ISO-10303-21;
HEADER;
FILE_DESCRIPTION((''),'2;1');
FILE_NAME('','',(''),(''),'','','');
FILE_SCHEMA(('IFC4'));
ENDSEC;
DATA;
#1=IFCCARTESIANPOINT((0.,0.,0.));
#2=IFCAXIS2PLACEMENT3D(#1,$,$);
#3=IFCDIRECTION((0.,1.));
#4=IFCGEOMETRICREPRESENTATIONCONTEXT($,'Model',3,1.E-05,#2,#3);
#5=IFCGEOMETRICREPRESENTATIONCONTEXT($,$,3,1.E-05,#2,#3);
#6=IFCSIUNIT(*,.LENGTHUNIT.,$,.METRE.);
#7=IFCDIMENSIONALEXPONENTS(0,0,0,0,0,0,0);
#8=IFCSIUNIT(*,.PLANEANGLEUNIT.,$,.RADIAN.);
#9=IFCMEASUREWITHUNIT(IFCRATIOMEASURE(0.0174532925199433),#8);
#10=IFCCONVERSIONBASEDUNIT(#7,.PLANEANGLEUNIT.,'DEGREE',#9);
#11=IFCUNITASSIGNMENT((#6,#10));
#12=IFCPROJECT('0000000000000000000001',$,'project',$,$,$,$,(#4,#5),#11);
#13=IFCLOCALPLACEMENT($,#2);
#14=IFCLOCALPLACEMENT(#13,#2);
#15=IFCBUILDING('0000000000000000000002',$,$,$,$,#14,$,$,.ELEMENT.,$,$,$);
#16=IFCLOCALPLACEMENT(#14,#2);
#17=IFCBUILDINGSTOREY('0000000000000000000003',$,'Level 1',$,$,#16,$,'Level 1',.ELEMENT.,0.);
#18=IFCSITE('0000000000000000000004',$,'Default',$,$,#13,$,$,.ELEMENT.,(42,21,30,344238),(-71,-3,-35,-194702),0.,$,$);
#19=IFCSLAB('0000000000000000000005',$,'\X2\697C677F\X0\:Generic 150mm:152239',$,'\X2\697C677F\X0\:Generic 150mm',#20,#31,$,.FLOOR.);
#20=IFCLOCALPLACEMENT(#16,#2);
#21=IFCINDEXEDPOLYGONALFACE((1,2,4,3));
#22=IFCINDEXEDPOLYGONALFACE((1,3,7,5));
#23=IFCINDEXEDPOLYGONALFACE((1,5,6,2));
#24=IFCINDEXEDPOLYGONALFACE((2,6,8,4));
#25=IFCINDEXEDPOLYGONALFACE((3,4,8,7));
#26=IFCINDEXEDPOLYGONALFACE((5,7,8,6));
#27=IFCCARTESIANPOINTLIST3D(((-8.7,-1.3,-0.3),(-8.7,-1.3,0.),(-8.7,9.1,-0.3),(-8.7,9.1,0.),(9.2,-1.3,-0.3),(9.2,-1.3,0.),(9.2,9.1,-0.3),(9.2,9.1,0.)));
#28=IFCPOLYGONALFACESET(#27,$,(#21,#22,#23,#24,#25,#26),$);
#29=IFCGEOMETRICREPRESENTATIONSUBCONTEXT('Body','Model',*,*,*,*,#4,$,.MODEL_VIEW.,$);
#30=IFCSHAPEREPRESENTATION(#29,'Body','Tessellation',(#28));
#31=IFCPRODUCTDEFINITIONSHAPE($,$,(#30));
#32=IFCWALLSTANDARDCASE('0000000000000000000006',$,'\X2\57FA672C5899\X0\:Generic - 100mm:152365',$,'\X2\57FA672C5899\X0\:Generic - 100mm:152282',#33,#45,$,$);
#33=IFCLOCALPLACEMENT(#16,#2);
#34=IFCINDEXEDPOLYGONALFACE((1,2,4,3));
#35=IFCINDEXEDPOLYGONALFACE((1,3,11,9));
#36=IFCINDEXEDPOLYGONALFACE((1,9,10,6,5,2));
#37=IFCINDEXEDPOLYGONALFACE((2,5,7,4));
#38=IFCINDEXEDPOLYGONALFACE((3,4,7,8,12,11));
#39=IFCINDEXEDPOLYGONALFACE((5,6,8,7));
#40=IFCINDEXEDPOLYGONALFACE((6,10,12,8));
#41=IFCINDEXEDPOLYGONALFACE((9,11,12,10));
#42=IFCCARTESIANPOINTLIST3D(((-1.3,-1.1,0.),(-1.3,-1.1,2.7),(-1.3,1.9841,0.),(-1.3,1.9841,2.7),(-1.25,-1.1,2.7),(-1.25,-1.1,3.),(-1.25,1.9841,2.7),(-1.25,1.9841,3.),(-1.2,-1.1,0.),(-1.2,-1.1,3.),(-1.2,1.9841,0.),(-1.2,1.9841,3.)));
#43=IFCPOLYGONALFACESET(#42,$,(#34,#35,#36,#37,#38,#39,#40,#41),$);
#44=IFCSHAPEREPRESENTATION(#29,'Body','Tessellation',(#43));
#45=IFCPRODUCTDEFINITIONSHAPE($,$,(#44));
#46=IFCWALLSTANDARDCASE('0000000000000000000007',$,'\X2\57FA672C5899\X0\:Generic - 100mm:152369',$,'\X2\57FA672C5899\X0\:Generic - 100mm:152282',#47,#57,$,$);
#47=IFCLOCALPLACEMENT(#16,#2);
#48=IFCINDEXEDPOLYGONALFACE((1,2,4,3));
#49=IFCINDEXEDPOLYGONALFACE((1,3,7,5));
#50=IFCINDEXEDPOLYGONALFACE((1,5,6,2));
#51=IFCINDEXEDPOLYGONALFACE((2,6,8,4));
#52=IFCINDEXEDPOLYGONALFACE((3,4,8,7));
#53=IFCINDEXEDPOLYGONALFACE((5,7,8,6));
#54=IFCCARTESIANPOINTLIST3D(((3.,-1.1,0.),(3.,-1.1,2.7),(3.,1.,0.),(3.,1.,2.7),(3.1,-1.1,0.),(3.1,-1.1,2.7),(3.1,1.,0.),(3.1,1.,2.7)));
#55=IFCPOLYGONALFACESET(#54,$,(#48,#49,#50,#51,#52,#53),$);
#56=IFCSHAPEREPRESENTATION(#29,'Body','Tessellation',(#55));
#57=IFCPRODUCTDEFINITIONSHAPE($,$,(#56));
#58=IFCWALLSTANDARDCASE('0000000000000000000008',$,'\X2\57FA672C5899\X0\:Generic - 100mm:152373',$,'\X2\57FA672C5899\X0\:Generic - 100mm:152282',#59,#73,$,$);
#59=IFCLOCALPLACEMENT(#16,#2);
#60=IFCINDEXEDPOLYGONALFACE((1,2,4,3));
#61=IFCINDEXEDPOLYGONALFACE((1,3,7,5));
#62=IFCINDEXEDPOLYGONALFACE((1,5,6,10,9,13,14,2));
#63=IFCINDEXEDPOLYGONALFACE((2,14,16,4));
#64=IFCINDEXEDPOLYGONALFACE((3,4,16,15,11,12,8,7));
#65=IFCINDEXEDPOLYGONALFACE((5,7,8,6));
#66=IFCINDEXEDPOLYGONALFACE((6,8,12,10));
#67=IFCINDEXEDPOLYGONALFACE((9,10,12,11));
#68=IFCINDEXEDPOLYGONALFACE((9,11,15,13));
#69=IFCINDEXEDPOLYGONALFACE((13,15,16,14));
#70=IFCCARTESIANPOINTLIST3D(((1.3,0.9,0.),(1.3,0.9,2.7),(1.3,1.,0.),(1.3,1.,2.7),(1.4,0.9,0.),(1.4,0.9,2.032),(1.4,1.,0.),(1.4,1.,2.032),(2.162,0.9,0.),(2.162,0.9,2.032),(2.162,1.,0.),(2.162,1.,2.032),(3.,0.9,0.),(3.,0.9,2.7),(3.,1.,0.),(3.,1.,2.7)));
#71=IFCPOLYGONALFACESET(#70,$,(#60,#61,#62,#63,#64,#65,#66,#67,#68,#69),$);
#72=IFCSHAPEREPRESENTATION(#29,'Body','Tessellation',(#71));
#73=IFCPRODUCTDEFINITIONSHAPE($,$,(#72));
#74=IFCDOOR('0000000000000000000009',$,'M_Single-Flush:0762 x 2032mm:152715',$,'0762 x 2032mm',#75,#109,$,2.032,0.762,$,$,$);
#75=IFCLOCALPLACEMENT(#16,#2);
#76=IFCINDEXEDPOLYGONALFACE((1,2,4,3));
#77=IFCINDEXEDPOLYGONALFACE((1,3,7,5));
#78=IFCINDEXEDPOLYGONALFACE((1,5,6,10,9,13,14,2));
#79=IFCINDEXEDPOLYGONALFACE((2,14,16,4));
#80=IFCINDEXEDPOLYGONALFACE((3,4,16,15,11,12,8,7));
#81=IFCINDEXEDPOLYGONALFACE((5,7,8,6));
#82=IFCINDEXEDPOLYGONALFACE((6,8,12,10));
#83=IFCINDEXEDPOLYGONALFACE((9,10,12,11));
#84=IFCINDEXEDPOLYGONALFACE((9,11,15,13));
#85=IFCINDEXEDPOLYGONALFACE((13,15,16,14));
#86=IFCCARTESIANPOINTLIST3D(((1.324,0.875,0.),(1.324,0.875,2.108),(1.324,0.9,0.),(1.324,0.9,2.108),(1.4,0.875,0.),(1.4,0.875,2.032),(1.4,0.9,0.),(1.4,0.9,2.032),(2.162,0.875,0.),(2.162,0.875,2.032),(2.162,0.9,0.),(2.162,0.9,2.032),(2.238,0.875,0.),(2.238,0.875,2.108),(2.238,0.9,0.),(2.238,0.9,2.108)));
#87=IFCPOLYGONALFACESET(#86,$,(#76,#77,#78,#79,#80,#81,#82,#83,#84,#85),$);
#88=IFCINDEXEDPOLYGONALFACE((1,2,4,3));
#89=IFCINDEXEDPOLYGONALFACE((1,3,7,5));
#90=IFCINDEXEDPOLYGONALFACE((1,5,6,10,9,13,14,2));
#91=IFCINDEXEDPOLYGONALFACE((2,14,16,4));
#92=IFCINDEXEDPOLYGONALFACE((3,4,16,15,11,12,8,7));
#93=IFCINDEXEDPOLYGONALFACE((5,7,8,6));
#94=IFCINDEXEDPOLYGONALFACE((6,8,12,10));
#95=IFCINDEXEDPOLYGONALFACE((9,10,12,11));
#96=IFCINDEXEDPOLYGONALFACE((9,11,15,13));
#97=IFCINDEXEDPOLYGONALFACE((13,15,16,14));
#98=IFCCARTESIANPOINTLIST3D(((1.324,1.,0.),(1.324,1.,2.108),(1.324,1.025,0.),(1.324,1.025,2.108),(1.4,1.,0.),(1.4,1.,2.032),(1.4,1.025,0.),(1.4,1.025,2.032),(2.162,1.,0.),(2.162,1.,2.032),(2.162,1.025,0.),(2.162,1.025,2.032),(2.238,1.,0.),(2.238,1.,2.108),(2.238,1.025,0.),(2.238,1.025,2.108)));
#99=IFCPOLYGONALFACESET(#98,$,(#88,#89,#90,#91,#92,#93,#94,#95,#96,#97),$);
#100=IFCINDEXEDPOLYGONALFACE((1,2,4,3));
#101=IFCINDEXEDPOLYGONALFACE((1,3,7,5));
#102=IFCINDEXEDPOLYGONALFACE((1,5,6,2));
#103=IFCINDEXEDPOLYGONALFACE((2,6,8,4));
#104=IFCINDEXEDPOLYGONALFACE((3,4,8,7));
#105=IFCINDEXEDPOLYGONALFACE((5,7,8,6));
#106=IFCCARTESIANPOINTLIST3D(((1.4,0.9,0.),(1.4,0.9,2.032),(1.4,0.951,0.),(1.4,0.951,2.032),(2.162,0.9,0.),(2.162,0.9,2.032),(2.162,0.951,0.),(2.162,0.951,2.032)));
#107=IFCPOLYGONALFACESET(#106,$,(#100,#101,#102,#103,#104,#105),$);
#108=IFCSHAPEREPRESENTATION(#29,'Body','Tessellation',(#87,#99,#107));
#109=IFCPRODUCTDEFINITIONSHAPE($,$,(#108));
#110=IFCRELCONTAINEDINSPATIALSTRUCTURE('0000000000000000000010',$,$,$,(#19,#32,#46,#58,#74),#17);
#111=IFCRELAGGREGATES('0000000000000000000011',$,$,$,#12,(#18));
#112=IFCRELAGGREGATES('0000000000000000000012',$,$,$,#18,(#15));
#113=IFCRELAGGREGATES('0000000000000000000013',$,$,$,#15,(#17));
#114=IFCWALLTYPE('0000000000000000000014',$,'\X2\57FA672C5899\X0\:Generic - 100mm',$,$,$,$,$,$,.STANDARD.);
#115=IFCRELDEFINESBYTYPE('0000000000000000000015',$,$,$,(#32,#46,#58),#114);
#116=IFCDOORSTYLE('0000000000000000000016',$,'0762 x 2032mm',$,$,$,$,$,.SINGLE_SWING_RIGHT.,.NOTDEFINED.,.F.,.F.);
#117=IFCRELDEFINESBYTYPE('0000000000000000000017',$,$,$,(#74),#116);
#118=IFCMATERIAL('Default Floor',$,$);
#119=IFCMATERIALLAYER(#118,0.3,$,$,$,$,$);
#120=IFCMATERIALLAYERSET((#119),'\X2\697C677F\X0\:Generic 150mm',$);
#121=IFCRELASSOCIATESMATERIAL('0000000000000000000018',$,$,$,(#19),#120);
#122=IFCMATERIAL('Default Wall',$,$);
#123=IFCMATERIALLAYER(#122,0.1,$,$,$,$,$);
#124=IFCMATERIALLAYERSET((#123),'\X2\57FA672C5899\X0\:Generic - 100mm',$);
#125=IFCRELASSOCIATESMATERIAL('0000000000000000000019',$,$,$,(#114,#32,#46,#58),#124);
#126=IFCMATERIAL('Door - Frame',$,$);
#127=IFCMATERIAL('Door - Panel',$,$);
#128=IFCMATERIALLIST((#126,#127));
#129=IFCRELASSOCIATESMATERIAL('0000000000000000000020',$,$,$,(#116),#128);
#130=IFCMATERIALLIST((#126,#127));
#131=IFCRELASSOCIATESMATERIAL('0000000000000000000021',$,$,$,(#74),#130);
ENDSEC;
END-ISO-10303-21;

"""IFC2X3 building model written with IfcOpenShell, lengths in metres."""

from ifc_helpers import new_model, entity, si_unit, converted_unit, direction, frame, frame_2d, origin, origin_2d_with_axis, place, context, subcontext, project, spatial, polyline, rectangle, outline, extrude, clip, bounded_halfspace, source, transform, mapped, material, material_list, layer, layer_set, layer_usage, type_object, type_shapes, element, fill, save


model = new_model("IFC2X3")

# Units and contexts
model_context = context("Model", 3, precision=1e-05, world=origin(), true_north=direction((0.0, 1.0)))
context_of_model = context(None, 3, precision=1e-05, world=origin(), true_north=direction((0.0, 1.0)))
body_context = subcontext(model_context, "Body", "Model", "MODEL_VIEW")
ifc_project = project(units=[si_unit("LENGTHUNIT", "METRE"), converted_unit("PLANEANGLEUNIT", "DEGREE", entity("IfcRatioMeasure", 0.0174532925199433), si_unit("PLANEANGLEUNIT", "RADIAN"), dimensions=[0, 0, 0, 0, 0, 0, 0])], contexts=[model_context, context_of_model])

# Site, building, storey
site_placement = place(None, origin())
site = spatial("IfcSite", under=ifc_project, at=site_placement, Name="Default", CompositionType="ELEMENT", RefLatitude=(42, 21, 30, 344238), RefLongitude=(-71, -3, -35, -194702), RefElevation=0.0)
building_placement = place(site_placement, origin())
building = spatial("IfcBuilding", under=site, at=building_placement, CompositionType="ELEMENT")
storey_placement = place(building_placement, origin())
storey = spatial("IfcBuildingStorey", under=building, at=storey_placement, Name="Level 1", LongName="Level 1", CompositionType="ELEMENT", Elevation=0.0)

# Slab
ifc_material_1 = material(Name="Default Floor")
ifc_layer_1 = layer(ifc_material_1, 0.3)
ifc_layer_set_1 = layer_set([ifc_layer_1], Name="楼板:Generic 150mm")
ifc_layer_usage_1 = layer_usage(ifc_layer_set_1, "AXIS3", "POSITIVE", 0.0)
slab_1_placement = place(storey_placement, origin())
element("IfcSlab", 1, at=slab_1_placement, inside=storey, material=ifc_layer_usage_1, Name="楼板:Generic 150mm:152239", ObjectType="楼板:Generic 150mm", PredefinedType="FLOOR", context=body_context, shape_type="SweptSolid", body=[
    extrude(rectangle(XDim=10.4, YDim=17.9, at=origin_2d_with_axis()), frame((0.25, 3.9, 0.0), z_axis=(0.0, 0.0, -1.0), x_axis=(0.0, 1.0, 0.0)), (0.0, 0.0, 1.0), 0.3),
])

# Walls
ifc_material_2 = material(Name="Default Wall")
ifc_layer_2 = layer(ifc_material_2, 0.1)
ifc_layer_set_2 = layer_set([ifc_layer_2], Name="基本墙:Generic - 100mm")
ifc_layer_usage_2 = layer_usage(ifc_layer_set_2, "AXIS2", "NEGATIVE", 0.05)
wall_type = type_object("IfcWallType", Name="基本墙:Generic - 100mm", PredefinedType="STANDARD", material=ifc_layer_set_2)
wall_1_placement = place(storey_placement, frame((-1.25, -1.1, 0.0), z_axis=(0.0, 0.0, 1.0), x_axis=(0.0, 1.0, 0.0)))
element("IfcWallStandardCase", 2, at=wall_1_placement, inside=storey, type_object=wall_type, material=ifc_layer_usage_2, Name="基本墙:Generic - 100mm:152365", ObjectType="基本墙:Generic - 100mm:152282", context=body_context, shape_type="Clipping", body=[
    clip(clip(extrude(rectangle(XDim=3.0841, YDim=0.1, at=frame_2d((1.5421, 0.0), x_axis=(-1.0, 0.0))), origin(), (0.0, 0.0, 1.0), 3.0), bounded_halfspace(frame((0.0, 0.0, 2.7), z_axis=(0.0, 0.0, -1.0), x_axis=(-1.0, 0.0, 0.0)), True, frame((0.0, 0.0, 2.7), z_axis=(0.0, 0.0, -1.0), x_axis=(-1.0, 0.0, 0.0)), polyline([(0.0, 0.0), (0.0, 0.05), (-3.0841, 0.05), (-3.0841, 0.0), (0.0, 0.0)]))), bounded_halfspace(frame((3.0841, 0.0, 2.7), z_axis=(0.0, 1.0, 0.0), x_axis=(0.0, 0.0, -1.0)), False, frame((3.0841, 0.0, 2.7), z_axis=(0.0, 1.0, 0.0), x_axis=(0.0, 0.0, -1.0)), polyline([(0.0, 0.0), (0.0, 3.0841), (-0.3, 3.0841), (-0.3, 0.0), (0.0, 0.0)]))),
])
ifc_layer_usage_3 = layer_usage(ifc_layer_set_2, "AXIS2", "NEGATIVE", 0.05)
wall_2_placement = place(storey_placement, frame((3.05, 1.0, 0.0), z_axis=(0.0, 0.0, 1.0), x_axis=(0.0, -1.0, 0.0)))
element("IfcWallStandardCase", 3, at=wall_2_placement, inside=storey, type_object=wall_type, material=ifc_layer_usage_3, Name="基本墙:Generic - 100mm:152369", ObjectType="基本墙:Generic - 100mm:152282", context=body_context, shape_type="Clipping", body=[
    clip(extrude(rectangle(XDim=2.1, YDim=0.1, at=frame_2d((1.05, 0.0), x_axis=(-1.0, 0.0))), origin(), (0.0, 0.0, 1.0), 3.0), bounded_halfspace(frame((0.0, -0.05, 2.7), z_axis=(0.0, 0.0, -1.0), x_axis=(1.0, 0.0, 0.0)), True, frame((0.0, -0.05, 2.7), z_axis=(0.0, 0.0, -1.0), x_axis=(1.0, 0.0, 0.0)), polyline([(0.0, 0.0), (0.0, -0.1), (2.1, -0.1), (2.1, 0.0), (0.1, 0.0), (0.0, 0.0)]))),
])

# Wall, opening, door
ifc_layer_usage_4 = layer_usage(ifc_layer_set_2, "AXIS2", "NEGATIVE", 0.05)
wall_3_placement = place(storey_placement, frame((1.3, 0.95, 0.0)))
wall_3 = element("IfcWallStandardCase", 4, at=wall_3_placement, inside=storey, type_object=wall_type, material=ifc_layer_usage_4, Name="基本墙:Generic - 100mm:152373", ObjectType="基本墙:Generic - 100mm:152282", context=body_context, shape_type="Clipping", body=[
    clip(extrude(rectangle(XDim=1.7, YDim=0.1, at=frame_2d((0.85, 0.0), x_axis=(-1.0, 0.0))), origin(), (0.0, 0.0, 1.0), 3.0), bounded_halfspace(frame((0.0, -0.05, 2.7), z_axis=(0.0, 0.0, -1.0), x_axis=(0.0, -1.0, 0.0)), True, frame((0.0, -0.05, 2.7), z_axis=(0.0, 0.0, -1.0), x_axis=(0.0, -1.0, 0.0)), polyline([(0.0, 0.0), (-0.1, 0.0), (-0.1, -1.7), (0.0, -1.7), (0.0, 0.0)]))),
])
opening_1_placement = place(wall_3_placement, frame((0.862, 0.05, 0.0)))
opening_1 = element("IfcOpeningElement", 5, at=opening_1_placement, cuts=wall_3, ObjectType="Opening", context=body_context, shape_type="SweptSolid", body=[
    extrude(rectangle(XDim=0.762, YDim=2.032, at=frame_2d((1.016, 0.381), x_axis=(0.0, 1.0))), frame((0.0, 0.0, 0.0), z_axis=(0.0, -1.0, 0.0), x_axis=(0.0, 0.0, 1.0)), (0.0, 0.0, 1.0), 0.1),
])
ifc_material_3 = material(Name="Door - Frame")
ifc_material_4 = material(Name="Door - Panel")
ifc_material_list_1 = material_list([ifc_material_3, ifc_material_4])
ifc_material_list_2 = material_list([ifc_material_3, ifc_material_4])
door_style = type_object("IfcDoorStyle", Name="0762 x 2032mm", ConstructionType="NOTDEFINED", OperationType="SINGLE_SWING_RIGHT", ParameterTakesPrecedence=False, Sizeable=False, material=ifc_material_list_2)
shared_shape = source(origin(), body_context, "Body", "SweptSolid", [
    extrude(outline(polyline([(-0.457, -1.073), (0.457, -1.073), (0.457, 1.035), (0.381, 1.035), (0.381, -0.997), (-0.381, -0.997), (-0.381, 1.035), (-0.457, 1.035), (-0.457, -1.073)])), frame((0.381, 0.1, 1.035), z_axis=(0.0, 1.0, 0.0), x_axis=(1.0, 0.0, 0.0)), (0.0, 0.0, 1.0), 0.025),
    extrude(outline(polyline([(-1.073, -0.457), (1.035, -0.457), (1.035, -0.381), (-0.997, -0.381), (-0.997, 0.381), (1.035, 0.381), (1.035, 0.457), (-1.073, 0.457), (-1.073, -0.457)])), frame((0.381, -0.025, 1.035), z_axis=(0.0, 1.0, 0.0), x_axis=(0.0, 0.0, -1.0)), (0.0, 0.0, 1.0), 0.025),
    extrude(rectangle(XDim=0.051, YDim=0.762, at=origin_2d_with_axis()), frame((0.381, 0.0745, 0.0), z_axis=(0.0, 0.0, 1.0), x_axis=(0.0, 1.0, 0.0)), (0.0, 0.0, 1.0), 2.032),
])
type_shapes(door_style, [shared_shape])
door_placement = place(opening_1_placement, frame((0.0, 0.0, 0.0), z_axis=(0.0, 0.0, 1.0), x_axis=(-1.0, 0.0, 0.0)))
door = element("IfcDoor", 6, at=door_placement, inside=storey, type_object=door_style, material=ifc_material_list_1, Name="M_Single-Flush:0762 x 2032mm:152715", ObjectType="0762 x 2032mm", OverallHeight=2.032, OverallWidth=0.762, context=body_context, shape_type="MappedRepresentation", body=[
    mapped(shared_shape, transform((0.0, 0.0, 0.0), scale=1.0)),
])
fill(opening_1, door)

save(model, "model.ifc")
